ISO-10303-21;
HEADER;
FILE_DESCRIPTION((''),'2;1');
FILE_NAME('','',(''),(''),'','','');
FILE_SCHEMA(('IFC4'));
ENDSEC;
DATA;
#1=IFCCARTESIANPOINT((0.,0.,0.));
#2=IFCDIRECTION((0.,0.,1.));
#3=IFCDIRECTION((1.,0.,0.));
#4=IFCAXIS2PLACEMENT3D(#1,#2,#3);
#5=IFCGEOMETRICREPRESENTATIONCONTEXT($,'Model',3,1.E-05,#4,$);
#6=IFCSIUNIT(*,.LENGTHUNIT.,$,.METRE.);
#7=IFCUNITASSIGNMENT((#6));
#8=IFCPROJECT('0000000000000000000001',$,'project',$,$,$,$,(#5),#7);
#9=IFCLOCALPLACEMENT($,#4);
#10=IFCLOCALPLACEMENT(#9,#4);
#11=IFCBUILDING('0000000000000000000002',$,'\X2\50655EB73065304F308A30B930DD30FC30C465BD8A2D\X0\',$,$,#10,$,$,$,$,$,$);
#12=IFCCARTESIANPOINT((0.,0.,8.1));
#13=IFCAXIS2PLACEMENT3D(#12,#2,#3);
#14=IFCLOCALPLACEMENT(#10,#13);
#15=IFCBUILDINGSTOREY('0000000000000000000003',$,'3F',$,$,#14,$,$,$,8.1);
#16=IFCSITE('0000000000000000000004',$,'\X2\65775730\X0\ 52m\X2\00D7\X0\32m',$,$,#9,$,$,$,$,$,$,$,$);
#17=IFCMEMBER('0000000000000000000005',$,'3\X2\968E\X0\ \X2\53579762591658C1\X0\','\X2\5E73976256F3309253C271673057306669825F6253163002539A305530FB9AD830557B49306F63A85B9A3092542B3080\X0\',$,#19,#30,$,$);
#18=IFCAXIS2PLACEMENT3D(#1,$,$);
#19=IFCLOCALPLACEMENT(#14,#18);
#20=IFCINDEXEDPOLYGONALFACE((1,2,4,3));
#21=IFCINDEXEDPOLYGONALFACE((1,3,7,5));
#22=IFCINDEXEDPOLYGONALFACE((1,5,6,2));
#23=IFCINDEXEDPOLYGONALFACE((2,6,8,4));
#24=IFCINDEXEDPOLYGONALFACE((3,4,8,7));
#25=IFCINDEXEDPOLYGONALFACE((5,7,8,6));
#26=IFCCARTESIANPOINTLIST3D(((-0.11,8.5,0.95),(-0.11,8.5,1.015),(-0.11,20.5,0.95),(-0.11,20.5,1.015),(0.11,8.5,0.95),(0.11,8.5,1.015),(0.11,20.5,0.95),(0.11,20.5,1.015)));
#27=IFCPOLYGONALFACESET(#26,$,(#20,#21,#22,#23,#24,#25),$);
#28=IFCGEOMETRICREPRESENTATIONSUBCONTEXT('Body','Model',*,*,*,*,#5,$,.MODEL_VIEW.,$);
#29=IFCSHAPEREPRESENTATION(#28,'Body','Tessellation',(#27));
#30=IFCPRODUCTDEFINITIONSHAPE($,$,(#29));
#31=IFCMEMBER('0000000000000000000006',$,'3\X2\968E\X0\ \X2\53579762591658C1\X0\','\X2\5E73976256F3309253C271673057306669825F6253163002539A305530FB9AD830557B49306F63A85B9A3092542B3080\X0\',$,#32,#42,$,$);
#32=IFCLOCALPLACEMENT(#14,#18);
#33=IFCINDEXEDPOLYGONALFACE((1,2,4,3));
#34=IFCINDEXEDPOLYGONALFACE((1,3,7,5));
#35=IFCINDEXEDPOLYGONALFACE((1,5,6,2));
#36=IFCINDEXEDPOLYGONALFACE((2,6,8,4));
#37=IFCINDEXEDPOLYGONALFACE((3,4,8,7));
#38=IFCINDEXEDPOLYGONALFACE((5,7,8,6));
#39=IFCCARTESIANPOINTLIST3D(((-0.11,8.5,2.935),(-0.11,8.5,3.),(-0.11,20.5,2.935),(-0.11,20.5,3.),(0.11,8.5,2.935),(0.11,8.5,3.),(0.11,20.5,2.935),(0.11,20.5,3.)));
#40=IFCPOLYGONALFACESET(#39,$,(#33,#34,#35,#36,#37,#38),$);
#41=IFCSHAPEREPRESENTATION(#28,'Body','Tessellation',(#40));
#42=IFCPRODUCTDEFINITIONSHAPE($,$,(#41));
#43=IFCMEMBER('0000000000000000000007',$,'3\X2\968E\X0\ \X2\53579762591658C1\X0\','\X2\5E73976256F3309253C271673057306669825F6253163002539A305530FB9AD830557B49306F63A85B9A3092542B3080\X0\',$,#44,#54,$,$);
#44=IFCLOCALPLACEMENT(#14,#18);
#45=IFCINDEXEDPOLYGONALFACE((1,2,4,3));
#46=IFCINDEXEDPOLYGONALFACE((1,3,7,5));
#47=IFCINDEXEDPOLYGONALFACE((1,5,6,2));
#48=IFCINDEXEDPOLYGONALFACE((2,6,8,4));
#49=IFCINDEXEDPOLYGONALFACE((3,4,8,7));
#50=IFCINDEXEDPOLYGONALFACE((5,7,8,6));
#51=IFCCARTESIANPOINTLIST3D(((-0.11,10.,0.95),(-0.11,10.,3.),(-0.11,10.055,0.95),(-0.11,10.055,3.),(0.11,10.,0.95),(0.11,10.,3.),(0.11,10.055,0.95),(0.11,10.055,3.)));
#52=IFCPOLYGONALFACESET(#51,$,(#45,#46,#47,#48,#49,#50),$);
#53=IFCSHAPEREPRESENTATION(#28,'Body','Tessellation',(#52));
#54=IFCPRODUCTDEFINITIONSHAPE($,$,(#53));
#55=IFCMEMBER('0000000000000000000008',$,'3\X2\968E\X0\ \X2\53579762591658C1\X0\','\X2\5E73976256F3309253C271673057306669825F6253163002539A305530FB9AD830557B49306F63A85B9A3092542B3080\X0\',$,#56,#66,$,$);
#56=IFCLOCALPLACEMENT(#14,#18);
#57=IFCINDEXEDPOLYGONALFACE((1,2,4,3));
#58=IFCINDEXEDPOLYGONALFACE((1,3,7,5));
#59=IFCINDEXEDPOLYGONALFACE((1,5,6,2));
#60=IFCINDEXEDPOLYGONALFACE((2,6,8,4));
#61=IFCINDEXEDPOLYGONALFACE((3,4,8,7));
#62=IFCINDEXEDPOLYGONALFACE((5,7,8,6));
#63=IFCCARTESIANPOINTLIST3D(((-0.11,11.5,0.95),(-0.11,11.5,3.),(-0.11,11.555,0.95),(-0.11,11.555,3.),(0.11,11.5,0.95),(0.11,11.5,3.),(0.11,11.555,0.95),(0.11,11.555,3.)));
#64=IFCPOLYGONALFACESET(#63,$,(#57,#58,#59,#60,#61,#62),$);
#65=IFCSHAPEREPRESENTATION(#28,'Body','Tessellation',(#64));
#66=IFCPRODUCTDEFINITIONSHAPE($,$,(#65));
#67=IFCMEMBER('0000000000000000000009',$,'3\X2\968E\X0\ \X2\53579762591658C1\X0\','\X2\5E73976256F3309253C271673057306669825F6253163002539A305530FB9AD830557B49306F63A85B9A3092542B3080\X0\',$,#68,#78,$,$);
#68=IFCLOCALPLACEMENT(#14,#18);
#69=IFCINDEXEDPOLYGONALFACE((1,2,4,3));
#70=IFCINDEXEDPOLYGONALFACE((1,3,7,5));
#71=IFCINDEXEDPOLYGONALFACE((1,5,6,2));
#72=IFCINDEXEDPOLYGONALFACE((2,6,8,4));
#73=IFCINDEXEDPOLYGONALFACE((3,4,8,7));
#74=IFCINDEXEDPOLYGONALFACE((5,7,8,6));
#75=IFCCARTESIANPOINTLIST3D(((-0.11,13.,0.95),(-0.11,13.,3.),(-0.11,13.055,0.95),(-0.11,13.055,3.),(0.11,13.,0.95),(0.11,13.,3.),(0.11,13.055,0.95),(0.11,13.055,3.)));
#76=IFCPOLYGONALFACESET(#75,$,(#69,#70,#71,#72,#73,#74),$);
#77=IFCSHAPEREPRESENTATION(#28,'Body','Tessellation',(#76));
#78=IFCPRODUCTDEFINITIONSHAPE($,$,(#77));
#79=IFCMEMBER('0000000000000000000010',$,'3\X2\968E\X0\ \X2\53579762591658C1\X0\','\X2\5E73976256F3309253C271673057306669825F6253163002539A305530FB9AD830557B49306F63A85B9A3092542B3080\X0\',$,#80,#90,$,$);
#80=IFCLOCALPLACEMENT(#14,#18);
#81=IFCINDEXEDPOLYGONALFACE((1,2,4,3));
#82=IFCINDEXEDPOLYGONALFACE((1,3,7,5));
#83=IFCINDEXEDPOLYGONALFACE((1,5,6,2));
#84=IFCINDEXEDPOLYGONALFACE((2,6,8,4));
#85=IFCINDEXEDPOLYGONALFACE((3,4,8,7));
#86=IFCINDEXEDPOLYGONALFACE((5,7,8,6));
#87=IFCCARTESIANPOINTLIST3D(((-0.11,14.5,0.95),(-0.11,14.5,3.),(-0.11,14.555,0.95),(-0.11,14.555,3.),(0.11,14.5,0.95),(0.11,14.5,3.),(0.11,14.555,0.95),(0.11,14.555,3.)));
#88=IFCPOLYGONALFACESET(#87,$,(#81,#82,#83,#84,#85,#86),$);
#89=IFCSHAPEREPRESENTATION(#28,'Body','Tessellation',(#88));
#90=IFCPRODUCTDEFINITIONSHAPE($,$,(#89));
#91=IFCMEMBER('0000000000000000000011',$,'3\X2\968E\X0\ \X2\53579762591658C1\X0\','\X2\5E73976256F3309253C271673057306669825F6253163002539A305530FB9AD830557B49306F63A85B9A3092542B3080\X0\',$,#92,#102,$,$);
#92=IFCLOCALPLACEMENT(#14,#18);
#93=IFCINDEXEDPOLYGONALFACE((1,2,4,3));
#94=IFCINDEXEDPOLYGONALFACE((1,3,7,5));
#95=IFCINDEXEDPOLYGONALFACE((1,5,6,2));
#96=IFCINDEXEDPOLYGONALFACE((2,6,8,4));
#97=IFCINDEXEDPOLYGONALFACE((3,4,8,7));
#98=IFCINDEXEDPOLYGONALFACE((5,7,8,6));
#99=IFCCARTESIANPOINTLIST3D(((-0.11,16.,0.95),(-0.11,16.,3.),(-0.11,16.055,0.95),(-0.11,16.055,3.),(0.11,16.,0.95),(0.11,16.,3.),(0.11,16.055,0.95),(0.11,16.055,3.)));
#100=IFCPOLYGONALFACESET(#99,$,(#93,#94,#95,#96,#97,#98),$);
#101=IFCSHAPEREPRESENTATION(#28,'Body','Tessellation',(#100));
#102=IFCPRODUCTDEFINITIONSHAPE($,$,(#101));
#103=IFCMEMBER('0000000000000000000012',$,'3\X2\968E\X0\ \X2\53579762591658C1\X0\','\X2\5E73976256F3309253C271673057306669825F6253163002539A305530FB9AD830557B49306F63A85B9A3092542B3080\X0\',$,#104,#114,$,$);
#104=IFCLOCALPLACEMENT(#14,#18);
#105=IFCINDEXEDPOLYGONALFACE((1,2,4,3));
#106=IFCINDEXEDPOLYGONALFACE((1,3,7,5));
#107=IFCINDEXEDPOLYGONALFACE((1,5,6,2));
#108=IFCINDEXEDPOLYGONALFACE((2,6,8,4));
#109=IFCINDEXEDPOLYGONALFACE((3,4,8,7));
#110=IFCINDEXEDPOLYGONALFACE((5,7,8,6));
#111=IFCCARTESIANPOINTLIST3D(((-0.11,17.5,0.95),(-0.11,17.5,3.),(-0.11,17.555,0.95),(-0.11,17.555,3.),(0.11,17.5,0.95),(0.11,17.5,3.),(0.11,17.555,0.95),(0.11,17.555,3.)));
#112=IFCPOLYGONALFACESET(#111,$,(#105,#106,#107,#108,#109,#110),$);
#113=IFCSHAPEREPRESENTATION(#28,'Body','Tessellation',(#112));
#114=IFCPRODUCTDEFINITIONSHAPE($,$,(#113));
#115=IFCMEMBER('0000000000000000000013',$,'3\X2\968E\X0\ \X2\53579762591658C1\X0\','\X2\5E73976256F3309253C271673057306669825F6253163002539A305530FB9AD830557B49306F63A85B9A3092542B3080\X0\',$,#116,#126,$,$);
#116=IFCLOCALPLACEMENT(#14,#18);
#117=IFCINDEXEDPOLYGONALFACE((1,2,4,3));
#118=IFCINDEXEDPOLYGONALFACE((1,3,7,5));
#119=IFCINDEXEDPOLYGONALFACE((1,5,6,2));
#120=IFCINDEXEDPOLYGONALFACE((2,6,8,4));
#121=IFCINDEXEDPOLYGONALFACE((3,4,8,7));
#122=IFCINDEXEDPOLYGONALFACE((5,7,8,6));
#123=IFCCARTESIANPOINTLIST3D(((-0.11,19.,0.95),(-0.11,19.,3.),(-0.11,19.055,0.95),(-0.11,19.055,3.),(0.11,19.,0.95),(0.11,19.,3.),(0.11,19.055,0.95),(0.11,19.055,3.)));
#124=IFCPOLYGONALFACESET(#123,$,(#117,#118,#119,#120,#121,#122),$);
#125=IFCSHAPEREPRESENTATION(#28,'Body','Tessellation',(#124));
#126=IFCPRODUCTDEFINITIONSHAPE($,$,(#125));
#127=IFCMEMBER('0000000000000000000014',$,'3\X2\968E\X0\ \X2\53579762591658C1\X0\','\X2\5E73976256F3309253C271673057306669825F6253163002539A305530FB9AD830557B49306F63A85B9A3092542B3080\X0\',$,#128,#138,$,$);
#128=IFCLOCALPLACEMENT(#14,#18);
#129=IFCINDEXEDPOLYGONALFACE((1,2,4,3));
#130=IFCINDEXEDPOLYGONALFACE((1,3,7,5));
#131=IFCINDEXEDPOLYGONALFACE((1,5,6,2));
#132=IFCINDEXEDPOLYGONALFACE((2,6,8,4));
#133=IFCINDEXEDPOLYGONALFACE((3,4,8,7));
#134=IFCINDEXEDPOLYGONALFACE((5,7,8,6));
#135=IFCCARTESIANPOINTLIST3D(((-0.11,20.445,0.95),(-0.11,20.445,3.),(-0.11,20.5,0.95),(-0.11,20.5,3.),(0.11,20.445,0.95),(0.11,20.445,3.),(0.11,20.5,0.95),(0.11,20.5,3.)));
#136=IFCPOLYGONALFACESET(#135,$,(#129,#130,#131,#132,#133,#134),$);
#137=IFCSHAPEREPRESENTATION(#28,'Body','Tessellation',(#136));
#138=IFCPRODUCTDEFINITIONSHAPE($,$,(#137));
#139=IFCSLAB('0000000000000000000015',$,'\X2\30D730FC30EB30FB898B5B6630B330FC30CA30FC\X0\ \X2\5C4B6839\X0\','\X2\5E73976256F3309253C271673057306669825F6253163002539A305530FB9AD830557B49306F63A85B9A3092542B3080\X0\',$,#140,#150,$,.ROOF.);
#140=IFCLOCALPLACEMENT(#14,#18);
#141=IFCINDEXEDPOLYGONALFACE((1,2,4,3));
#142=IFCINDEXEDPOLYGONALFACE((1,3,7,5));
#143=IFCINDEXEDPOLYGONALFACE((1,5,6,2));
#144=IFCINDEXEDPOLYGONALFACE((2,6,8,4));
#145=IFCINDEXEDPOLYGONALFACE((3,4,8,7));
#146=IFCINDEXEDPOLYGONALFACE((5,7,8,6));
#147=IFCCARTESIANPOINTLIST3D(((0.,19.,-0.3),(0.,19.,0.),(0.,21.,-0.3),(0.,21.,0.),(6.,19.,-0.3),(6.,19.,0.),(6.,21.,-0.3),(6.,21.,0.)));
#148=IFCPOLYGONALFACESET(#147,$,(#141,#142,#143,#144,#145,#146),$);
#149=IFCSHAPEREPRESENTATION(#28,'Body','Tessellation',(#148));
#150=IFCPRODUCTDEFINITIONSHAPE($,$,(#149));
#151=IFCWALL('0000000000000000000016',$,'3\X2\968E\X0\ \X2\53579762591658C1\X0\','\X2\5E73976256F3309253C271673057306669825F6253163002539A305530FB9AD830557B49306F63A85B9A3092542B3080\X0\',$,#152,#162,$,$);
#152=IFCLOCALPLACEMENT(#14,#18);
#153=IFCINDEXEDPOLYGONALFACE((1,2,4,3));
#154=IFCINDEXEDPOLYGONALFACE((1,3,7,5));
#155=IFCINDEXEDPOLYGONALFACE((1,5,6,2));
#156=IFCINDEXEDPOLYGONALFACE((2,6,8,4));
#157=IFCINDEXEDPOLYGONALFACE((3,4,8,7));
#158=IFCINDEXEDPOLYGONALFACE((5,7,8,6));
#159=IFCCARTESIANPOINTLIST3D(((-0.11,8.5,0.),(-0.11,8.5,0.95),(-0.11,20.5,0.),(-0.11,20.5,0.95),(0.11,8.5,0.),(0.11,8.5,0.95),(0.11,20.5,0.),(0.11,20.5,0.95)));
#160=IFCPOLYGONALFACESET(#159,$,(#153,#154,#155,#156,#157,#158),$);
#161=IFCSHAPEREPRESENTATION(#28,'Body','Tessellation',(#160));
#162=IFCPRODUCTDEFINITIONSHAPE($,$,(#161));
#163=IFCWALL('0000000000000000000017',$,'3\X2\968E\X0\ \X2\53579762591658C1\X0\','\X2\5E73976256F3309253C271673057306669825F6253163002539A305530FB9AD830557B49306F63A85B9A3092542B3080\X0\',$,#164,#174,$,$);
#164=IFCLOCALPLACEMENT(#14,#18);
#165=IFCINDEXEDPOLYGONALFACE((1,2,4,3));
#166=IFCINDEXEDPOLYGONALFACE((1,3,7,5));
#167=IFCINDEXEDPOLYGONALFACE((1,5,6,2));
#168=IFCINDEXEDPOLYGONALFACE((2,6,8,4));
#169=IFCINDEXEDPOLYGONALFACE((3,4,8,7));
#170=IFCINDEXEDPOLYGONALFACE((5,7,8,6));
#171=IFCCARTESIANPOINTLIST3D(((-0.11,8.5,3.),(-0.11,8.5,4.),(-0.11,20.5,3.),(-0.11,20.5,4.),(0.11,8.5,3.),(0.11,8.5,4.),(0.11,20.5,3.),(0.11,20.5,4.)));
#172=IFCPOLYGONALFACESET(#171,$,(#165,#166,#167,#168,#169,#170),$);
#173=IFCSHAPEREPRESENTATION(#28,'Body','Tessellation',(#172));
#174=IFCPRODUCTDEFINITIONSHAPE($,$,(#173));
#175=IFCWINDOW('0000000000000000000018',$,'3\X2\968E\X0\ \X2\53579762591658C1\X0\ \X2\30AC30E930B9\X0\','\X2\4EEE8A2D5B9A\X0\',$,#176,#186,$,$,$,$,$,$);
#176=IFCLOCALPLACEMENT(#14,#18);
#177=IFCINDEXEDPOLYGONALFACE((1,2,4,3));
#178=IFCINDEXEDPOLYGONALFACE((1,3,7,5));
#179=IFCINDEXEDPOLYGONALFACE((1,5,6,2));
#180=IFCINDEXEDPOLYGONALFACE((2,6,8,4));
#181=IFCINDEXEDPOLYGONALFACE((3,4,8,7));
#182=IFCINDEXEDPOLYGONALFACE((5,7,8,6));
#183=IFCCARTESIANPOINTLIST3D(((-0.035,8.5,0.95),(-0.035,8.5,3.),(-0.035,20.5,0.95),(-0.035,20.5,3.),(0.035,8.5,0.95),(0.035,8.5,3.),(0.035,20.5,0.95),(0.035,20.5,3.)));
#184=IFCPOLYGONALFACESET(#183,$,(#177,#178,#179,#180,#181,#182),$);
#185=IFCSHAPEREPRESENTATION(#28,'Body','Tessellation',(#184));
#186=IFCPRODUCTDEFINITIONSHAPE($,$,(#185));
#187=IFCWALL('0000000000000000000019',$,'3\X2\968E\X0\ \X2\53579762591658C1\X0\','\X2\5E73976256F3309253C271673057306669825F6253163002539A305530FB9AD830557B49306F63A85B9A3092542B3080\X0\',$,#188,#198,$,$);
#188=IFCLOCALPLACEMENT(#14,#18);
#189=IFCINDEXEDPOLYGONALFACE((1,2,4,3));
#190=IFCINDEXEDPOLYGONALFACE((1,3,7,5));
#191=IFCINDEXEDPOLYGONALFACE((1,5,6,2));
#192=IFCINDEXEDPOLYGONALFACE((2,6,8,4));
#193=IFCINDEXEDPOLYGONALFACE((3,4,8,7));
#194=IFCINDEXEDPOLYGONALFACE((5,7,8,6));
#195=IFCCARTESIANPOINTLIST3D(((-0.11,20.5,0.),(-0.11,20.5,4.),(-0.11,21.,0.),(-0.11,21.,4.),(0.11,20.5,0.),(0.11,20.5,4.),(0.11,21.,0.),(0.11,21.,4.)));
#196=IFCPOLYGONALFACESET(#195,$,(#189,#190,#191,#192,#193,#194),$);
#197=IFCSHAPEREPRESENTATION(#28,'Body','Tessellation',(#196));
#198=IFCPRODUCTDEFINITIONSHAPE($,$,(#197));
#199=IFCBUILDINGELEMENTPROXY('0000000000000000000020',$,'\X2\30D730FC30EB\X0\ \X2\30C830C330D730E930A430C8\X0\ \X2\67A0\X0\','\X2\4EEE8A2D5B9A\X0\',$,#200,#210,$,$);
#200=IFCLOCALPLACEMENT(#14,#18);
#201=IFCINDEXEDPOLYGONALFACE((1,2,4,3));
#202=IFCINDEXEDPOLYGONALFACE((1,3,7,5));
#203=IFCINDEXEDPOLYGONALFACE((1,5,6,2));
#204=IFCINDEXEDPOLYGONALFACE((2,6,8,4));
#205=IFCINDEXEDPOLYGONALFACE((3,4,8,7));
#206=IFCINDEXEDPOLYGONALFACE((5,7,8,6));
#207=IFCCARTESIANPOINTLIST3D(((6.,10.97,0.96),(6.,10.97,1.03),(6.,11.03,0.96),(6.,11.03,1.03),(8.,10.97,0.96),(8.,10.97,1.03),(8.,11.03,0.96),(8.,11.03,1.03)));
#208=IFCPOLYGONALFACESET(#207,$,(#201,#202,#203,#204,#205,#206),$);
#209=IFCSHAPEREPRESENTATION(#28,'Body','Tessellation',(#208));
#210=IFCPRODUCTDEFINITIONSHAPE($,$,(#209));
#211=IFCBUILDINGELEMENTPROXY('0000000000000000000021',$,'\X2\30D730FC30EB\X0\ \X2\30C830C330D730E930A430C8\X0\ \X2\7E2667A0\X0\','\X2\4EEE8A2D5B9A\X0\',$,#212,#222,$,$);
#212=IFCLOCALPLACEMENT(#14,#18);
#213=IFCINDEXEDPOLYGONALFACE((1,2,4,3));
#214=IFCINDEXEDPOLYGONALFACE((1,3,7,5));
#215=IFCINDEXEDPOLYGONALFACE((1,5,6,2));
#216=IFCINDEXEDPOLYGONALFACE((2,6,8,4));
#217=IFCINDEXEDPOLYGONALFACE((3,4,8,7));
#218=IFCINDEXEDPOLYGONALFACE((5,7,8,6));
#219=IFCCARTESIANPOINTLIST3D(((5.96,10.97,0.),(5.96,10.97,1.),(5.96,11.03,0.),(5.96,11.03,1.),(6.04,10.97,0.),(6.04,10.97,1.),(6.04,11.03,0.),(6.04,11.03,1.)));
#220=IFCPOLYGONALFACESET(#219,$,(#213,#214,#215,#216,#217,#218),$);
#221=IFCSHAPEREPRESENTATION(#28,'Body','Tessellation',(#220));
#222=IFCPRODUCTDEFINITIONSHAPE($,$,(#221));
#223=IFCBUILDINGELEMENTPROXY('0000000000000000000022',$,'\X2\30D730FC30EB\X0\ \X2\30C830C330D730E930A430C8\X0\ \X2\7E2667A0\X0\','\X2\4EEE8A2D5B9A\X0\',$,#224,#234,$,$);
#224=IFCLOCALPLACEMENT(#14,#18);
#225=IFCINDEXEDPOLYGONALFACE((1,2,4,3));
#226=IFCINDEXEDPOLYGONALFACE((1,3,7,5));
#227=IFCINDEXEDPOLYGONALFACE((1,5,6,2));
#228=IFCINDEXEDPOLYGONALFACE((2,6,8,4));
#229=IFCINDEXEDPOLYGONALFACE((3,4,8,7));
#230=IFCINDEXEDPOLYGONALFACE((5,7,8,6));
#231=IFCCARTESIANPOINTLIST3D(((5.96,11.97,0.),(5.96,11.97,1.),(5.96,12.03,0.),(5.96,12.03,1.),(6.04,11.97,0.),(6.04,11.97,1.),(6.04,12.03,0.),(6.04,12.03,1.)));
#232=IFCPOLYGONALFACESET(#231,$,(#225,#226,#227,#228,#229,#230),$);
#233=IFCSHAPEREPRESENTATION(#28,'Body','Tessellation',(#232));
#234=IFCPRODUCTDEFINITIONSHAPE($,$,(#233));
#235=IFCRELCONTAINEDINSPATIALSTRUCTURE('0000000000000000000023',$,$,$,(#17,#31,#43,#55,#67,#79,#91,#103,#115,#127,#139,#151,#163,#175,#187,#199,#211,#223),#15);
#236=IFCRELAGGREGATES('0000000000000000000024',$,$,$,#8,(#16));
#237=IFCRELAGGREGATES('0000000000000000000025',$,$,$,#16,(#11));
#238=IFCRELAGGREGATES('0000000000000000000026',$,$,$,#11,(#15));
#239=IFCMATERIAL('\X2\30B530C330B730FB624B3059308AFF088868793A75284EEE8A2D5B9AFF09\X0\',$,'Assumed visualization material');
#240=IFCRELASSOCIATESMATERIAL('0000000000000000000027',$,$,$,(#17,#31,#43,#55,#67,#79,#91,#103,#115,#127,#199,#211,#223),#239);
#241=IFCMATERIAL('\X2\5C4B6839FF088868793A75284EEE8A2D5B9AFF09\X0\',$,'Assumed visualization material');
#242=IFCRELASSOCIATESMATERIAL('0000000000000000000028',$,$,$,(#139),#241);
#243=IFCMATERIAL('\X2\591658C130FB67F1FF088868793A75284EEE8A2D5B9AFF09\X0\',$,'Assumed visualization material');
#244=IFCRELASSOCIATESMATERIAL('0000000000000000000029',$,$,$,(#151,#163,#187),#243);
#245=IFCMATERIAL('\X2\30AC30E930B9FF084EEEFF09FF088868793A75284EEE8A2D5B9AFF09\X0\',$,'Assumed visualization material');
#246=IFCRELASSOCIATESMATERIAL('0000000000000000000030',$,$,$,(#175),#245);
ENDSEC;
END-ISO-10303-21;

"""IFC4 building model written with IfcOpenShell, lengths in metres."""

from ifc_helpers import new_model, si_unit, frame, origin_with_axes, place, context, subcontext, project, spatial, rectangle, extrude, material, element, save


model = new_model("IFC4")

# Units and contexts
model_context = context("Model", 3, precision=1e-05, world=origin_with_axes())
body_context = subcontext(model_context, "Body", "Model", "MODEL_VIEW")
ifc_project = project(units=[si_unit("LENGTHUNIT", "METRE")], contexts=[model_context])

# Site, building, storey
site_placement = place(None, origin_with_axes())
site = spatial("IfcSite", under=ifc_project, at=site_placement, Name="敷地 52m×32m")
building_placement = place(site_placement, origin_with_axes())
building = spatial("IfcBuilding", under=site, at=building_placement, Name="健康づくりスポーツ施設")
storey_placement = place(building_placement, frame((0.0, 0.0, 8.1), z_axis=(0.0, 0.0, 1.0), x_axis=(1.0, 0.0, 0.0)))
storey = spatial("IfcBuildingStorey", under=building, at=storey_placement, Name="3F", Elevation=8.1)

# Members
ifc_material_1 = material(Name="サッシ・手すり（表示用仮設定）", Category="Assumed visualization material")
for number, where, z_axis, x_axis, name in (
    (1, (0.0, 14.5, 0.95), (0.0, 0.0, 1.0), (1.0, 0.0, 0.0), "3階 南面外壁"),
    (2, (0.0, 14.5, 2.935), (0.0, 0.0, 1.0), (1.0, 0.0, 0.0), "3階 南面外壁"),
):
    element("IfcMember", number, at=place(storey_placement, frame(where, z_axis=z_axis, x_axis=x_axis)), inside=storey, material=ifc_material_1, Name=name, Description="平面図を参照して概形化。厚さ・高さ等は推定を含む", context=body_context, shape_type="SweptSolid", body=[
        extrude(rectangle(XDim=0.22, YDim=12.0), origin_with_axes(), (0.0, 0.0, 1.0), 0.065),
    ])
for number, where, z_axis, x_axis, name in (
    (3, (0.0, 10.0275, 0.95), (0.0, 0.0, 1.0), (1.0, 0.0, 0.0), "3階 南面外壁"),
    (4, (0.0, 11.5275, 0.95), (0.0, 0.0, 1.0), (1.0, 0.0, 0.0), "3階 南面外壁"),
    (5, (0.0, 13.0275, 0.95), (0.0, 0.0, 1.0), (1.0, 0.0, 0.0), "3階 南面外壁"),
    (6, (0.0, 14.5275, 0.95), (0.0, 0.0, 1.0), (1.0, 0.0, 0.0), "3階 南面外壁"),
    (7, (0.0, 16.0275, 0.95), (0.0, 0.0, 1.0), (1.0, 0.0, 0.0), "3階 南面外壁"),
    (8, (0.0, 17.5275, 0.95), (0.0, 0.0, 1.0), (1.0, 0.0, 0.0), "3階 南面外壁"),
    (9, (0.0, 19.0275, 0.95), (0.0, 0.0, 1.0), (1.0, 0.0, 0.0), "3階 南面外壁"),
    (10, (0.0, 20.4725, 0.95), (0.0, 0.0, 1.0), (1.0, 0.0, 0.0), "3階 南面外壁"),
):
    element("IfcMember", number, at=place(storey_placement, frame(where, z_axis=z_axis, x_axis=x_axis)), inside=storey, material=ifc_material_1, Name=name, Description="平面図を参照して概形化。厚さ・高さ等は推定を含む", context=body_context, shape_type="SweptSolid", body=[
        extrude(rectangle(XDim=0.22, YDim=0.055), origin_with_axes(), (0.0, 0.0, 1.0), 2.05),
    ])

# Slab
ifc_material_2 = material(Name="屋根（表示用仮設定）", Category="Assumed visualization material")
slab_placement = place(storey_placement, frame((3.0, 20.0, -0.3), z_axis=(0.0, 0.0, 1.0), x_axis=(1.0, 0.0, 0.0)))
element("IfcSlab", 11, at=slab_placement, inside=storey, material=ifc_material_2, Name="プール・見学コーナー 屋根", Description="平面図を参照して概形化。厚さ・高さ等は推定を含む", PredefinedType="ROOF", context=body_context, shape_type="SweptSolid", body=[
    extrude(rectangle(XDim=6.0, YDim=2.0), origin_with_axes(), (0.0, 0.0, 1.0), 0.3),
])

# Walls
ifc_material_3 = material(Name="外壁・柱（表示用仮設定）", Category="Assumed visualization material")
wall_1_placement = place(storey_placement, frame((0.0, 14.5, 0.0), z_axis=(0.0, 0.0, 1.0), x_axis=(1.0, 0.0, 0.0)))
element("IfcWall", 12, at=wall_1_placement, inside=storey, material=ifc_material_3, Name="3階 南面外壁", Description="平面図を参照して概形化。厚さ・高さ等は推定を含む", context=body_context, shape_type="SweptSolid", body=[
    extrude(rectangle(XDim=0.22, YDim=12.0), origin_with_axes(), (0.0, 0.0, 1.0), 0.95),
])
wall_2_placement = place(storey_placement, frame((0.0, 14.5, 3.0), z_axis=(0.0, 0.0, 1.0), x_axis=(1.0, 0.0, 0.0)))
element("IfcWall", 13, at=wall_2_placement, inside=storey, material=ifc_material_3, Name="3階 南面外壁", Description="平面図を参照して概形化。厚さ・高さ等は推定を含む", context=body_context, shape_type="SweptSolid", body=[
    extrude(rectangle(XDim=0.22, YDim=12.0), origin_with_axes(), (0.0, 0.0, 1.0), 1.0),
])

# Window
ifc_material_4 = material(Name="ガラス（仮）（表示用仮設定）", Category="Assumed visualization material")
window_placement = place(storey_placement, frame((0.0, 14.5, 0.95), z_axis=(0.0, 0.0, 1.0), x_axis=(1.0, 0.0, 0.0)))
element("IfcWindow", 14, at=window_placement, inside=storey, material=ifc_material_4, Name="3階 南面外壁 ガラス", Description="仮設定", context=body_context, shape_type="SweptSolid", body=[
    extrude(rectangle(XDim=0.07, YDim=12.0), origin_with_axes(), (0.0, 0.0, 1.0), 2.05),
])

# Wall
wall_3_placement = place(storey_placement, frame((0.0, 20.75, 0.0), z_axis=(0.0, 0.0, 1.0), x_axis=(1.0, 0.0, 0.0)))
element("IfcWall", 15, at=wall_3_placement, inside=storey, material=ifc_material_3, Name="3階 南面外壁", Description="平面図を参照して概形化。厚さ・高さ等は推定を含む", context=body_context, shape_type="SweptSolid", body=[
    extrude(rectangle(XDim=0.22, YDim=0.5), origin_with_axes(), (0.0, 0.0, 1.0), 4.0),
])

# Building element proxies
proxy_placement = place(storey_placement, frame((7.0, 11.0, 0.96), z_axis=(0.0, 0.0, 1.0), x_axis=(1.0, 0.0, 0.0)))
element("IfcBuildingElementProxy", 16, at=proxy_placement, inside=storey, material=ifc_material_1, Name="プール トップライト 枠", Description="仮設定", context=body_context, shape_type="SweptSolid", body=[
    extrude(rectangle(XDim=2.0, YDim=0.06), origin_with_axes(), (0.0, 0.0, 1.0), 0.07),
])
for number, where, z_axis, x_axis, name in (
    (17, (6.0, 11.0, 0.0), (0.0, 0.0, 1.0), (1.0, 0.0, 0.0), "プール トップライト 縦枠"),
    (18, (6.0, 12.0, 0.0), (0.0, 0.0, 1.0), (1.0, 0.0, 0.0), "プール トップライト 縦枠"),
):
    element("IfcBuildingElementProxy", number, at=place(storey_placement, frame(where, z_axis=z_axis, x_axis=x_axis)), inside=storey, material=ifc_material_1, Name=name, Description="仮設定", context=body_context, shape_type="SweptSolid", body=[
        extrude(rectangle(XDim=0.08, YDim=0.06), origin_with_axes(), (0.0, 0.0, 1.0), 1.0),
    ])

save(model, "model.ifc")
